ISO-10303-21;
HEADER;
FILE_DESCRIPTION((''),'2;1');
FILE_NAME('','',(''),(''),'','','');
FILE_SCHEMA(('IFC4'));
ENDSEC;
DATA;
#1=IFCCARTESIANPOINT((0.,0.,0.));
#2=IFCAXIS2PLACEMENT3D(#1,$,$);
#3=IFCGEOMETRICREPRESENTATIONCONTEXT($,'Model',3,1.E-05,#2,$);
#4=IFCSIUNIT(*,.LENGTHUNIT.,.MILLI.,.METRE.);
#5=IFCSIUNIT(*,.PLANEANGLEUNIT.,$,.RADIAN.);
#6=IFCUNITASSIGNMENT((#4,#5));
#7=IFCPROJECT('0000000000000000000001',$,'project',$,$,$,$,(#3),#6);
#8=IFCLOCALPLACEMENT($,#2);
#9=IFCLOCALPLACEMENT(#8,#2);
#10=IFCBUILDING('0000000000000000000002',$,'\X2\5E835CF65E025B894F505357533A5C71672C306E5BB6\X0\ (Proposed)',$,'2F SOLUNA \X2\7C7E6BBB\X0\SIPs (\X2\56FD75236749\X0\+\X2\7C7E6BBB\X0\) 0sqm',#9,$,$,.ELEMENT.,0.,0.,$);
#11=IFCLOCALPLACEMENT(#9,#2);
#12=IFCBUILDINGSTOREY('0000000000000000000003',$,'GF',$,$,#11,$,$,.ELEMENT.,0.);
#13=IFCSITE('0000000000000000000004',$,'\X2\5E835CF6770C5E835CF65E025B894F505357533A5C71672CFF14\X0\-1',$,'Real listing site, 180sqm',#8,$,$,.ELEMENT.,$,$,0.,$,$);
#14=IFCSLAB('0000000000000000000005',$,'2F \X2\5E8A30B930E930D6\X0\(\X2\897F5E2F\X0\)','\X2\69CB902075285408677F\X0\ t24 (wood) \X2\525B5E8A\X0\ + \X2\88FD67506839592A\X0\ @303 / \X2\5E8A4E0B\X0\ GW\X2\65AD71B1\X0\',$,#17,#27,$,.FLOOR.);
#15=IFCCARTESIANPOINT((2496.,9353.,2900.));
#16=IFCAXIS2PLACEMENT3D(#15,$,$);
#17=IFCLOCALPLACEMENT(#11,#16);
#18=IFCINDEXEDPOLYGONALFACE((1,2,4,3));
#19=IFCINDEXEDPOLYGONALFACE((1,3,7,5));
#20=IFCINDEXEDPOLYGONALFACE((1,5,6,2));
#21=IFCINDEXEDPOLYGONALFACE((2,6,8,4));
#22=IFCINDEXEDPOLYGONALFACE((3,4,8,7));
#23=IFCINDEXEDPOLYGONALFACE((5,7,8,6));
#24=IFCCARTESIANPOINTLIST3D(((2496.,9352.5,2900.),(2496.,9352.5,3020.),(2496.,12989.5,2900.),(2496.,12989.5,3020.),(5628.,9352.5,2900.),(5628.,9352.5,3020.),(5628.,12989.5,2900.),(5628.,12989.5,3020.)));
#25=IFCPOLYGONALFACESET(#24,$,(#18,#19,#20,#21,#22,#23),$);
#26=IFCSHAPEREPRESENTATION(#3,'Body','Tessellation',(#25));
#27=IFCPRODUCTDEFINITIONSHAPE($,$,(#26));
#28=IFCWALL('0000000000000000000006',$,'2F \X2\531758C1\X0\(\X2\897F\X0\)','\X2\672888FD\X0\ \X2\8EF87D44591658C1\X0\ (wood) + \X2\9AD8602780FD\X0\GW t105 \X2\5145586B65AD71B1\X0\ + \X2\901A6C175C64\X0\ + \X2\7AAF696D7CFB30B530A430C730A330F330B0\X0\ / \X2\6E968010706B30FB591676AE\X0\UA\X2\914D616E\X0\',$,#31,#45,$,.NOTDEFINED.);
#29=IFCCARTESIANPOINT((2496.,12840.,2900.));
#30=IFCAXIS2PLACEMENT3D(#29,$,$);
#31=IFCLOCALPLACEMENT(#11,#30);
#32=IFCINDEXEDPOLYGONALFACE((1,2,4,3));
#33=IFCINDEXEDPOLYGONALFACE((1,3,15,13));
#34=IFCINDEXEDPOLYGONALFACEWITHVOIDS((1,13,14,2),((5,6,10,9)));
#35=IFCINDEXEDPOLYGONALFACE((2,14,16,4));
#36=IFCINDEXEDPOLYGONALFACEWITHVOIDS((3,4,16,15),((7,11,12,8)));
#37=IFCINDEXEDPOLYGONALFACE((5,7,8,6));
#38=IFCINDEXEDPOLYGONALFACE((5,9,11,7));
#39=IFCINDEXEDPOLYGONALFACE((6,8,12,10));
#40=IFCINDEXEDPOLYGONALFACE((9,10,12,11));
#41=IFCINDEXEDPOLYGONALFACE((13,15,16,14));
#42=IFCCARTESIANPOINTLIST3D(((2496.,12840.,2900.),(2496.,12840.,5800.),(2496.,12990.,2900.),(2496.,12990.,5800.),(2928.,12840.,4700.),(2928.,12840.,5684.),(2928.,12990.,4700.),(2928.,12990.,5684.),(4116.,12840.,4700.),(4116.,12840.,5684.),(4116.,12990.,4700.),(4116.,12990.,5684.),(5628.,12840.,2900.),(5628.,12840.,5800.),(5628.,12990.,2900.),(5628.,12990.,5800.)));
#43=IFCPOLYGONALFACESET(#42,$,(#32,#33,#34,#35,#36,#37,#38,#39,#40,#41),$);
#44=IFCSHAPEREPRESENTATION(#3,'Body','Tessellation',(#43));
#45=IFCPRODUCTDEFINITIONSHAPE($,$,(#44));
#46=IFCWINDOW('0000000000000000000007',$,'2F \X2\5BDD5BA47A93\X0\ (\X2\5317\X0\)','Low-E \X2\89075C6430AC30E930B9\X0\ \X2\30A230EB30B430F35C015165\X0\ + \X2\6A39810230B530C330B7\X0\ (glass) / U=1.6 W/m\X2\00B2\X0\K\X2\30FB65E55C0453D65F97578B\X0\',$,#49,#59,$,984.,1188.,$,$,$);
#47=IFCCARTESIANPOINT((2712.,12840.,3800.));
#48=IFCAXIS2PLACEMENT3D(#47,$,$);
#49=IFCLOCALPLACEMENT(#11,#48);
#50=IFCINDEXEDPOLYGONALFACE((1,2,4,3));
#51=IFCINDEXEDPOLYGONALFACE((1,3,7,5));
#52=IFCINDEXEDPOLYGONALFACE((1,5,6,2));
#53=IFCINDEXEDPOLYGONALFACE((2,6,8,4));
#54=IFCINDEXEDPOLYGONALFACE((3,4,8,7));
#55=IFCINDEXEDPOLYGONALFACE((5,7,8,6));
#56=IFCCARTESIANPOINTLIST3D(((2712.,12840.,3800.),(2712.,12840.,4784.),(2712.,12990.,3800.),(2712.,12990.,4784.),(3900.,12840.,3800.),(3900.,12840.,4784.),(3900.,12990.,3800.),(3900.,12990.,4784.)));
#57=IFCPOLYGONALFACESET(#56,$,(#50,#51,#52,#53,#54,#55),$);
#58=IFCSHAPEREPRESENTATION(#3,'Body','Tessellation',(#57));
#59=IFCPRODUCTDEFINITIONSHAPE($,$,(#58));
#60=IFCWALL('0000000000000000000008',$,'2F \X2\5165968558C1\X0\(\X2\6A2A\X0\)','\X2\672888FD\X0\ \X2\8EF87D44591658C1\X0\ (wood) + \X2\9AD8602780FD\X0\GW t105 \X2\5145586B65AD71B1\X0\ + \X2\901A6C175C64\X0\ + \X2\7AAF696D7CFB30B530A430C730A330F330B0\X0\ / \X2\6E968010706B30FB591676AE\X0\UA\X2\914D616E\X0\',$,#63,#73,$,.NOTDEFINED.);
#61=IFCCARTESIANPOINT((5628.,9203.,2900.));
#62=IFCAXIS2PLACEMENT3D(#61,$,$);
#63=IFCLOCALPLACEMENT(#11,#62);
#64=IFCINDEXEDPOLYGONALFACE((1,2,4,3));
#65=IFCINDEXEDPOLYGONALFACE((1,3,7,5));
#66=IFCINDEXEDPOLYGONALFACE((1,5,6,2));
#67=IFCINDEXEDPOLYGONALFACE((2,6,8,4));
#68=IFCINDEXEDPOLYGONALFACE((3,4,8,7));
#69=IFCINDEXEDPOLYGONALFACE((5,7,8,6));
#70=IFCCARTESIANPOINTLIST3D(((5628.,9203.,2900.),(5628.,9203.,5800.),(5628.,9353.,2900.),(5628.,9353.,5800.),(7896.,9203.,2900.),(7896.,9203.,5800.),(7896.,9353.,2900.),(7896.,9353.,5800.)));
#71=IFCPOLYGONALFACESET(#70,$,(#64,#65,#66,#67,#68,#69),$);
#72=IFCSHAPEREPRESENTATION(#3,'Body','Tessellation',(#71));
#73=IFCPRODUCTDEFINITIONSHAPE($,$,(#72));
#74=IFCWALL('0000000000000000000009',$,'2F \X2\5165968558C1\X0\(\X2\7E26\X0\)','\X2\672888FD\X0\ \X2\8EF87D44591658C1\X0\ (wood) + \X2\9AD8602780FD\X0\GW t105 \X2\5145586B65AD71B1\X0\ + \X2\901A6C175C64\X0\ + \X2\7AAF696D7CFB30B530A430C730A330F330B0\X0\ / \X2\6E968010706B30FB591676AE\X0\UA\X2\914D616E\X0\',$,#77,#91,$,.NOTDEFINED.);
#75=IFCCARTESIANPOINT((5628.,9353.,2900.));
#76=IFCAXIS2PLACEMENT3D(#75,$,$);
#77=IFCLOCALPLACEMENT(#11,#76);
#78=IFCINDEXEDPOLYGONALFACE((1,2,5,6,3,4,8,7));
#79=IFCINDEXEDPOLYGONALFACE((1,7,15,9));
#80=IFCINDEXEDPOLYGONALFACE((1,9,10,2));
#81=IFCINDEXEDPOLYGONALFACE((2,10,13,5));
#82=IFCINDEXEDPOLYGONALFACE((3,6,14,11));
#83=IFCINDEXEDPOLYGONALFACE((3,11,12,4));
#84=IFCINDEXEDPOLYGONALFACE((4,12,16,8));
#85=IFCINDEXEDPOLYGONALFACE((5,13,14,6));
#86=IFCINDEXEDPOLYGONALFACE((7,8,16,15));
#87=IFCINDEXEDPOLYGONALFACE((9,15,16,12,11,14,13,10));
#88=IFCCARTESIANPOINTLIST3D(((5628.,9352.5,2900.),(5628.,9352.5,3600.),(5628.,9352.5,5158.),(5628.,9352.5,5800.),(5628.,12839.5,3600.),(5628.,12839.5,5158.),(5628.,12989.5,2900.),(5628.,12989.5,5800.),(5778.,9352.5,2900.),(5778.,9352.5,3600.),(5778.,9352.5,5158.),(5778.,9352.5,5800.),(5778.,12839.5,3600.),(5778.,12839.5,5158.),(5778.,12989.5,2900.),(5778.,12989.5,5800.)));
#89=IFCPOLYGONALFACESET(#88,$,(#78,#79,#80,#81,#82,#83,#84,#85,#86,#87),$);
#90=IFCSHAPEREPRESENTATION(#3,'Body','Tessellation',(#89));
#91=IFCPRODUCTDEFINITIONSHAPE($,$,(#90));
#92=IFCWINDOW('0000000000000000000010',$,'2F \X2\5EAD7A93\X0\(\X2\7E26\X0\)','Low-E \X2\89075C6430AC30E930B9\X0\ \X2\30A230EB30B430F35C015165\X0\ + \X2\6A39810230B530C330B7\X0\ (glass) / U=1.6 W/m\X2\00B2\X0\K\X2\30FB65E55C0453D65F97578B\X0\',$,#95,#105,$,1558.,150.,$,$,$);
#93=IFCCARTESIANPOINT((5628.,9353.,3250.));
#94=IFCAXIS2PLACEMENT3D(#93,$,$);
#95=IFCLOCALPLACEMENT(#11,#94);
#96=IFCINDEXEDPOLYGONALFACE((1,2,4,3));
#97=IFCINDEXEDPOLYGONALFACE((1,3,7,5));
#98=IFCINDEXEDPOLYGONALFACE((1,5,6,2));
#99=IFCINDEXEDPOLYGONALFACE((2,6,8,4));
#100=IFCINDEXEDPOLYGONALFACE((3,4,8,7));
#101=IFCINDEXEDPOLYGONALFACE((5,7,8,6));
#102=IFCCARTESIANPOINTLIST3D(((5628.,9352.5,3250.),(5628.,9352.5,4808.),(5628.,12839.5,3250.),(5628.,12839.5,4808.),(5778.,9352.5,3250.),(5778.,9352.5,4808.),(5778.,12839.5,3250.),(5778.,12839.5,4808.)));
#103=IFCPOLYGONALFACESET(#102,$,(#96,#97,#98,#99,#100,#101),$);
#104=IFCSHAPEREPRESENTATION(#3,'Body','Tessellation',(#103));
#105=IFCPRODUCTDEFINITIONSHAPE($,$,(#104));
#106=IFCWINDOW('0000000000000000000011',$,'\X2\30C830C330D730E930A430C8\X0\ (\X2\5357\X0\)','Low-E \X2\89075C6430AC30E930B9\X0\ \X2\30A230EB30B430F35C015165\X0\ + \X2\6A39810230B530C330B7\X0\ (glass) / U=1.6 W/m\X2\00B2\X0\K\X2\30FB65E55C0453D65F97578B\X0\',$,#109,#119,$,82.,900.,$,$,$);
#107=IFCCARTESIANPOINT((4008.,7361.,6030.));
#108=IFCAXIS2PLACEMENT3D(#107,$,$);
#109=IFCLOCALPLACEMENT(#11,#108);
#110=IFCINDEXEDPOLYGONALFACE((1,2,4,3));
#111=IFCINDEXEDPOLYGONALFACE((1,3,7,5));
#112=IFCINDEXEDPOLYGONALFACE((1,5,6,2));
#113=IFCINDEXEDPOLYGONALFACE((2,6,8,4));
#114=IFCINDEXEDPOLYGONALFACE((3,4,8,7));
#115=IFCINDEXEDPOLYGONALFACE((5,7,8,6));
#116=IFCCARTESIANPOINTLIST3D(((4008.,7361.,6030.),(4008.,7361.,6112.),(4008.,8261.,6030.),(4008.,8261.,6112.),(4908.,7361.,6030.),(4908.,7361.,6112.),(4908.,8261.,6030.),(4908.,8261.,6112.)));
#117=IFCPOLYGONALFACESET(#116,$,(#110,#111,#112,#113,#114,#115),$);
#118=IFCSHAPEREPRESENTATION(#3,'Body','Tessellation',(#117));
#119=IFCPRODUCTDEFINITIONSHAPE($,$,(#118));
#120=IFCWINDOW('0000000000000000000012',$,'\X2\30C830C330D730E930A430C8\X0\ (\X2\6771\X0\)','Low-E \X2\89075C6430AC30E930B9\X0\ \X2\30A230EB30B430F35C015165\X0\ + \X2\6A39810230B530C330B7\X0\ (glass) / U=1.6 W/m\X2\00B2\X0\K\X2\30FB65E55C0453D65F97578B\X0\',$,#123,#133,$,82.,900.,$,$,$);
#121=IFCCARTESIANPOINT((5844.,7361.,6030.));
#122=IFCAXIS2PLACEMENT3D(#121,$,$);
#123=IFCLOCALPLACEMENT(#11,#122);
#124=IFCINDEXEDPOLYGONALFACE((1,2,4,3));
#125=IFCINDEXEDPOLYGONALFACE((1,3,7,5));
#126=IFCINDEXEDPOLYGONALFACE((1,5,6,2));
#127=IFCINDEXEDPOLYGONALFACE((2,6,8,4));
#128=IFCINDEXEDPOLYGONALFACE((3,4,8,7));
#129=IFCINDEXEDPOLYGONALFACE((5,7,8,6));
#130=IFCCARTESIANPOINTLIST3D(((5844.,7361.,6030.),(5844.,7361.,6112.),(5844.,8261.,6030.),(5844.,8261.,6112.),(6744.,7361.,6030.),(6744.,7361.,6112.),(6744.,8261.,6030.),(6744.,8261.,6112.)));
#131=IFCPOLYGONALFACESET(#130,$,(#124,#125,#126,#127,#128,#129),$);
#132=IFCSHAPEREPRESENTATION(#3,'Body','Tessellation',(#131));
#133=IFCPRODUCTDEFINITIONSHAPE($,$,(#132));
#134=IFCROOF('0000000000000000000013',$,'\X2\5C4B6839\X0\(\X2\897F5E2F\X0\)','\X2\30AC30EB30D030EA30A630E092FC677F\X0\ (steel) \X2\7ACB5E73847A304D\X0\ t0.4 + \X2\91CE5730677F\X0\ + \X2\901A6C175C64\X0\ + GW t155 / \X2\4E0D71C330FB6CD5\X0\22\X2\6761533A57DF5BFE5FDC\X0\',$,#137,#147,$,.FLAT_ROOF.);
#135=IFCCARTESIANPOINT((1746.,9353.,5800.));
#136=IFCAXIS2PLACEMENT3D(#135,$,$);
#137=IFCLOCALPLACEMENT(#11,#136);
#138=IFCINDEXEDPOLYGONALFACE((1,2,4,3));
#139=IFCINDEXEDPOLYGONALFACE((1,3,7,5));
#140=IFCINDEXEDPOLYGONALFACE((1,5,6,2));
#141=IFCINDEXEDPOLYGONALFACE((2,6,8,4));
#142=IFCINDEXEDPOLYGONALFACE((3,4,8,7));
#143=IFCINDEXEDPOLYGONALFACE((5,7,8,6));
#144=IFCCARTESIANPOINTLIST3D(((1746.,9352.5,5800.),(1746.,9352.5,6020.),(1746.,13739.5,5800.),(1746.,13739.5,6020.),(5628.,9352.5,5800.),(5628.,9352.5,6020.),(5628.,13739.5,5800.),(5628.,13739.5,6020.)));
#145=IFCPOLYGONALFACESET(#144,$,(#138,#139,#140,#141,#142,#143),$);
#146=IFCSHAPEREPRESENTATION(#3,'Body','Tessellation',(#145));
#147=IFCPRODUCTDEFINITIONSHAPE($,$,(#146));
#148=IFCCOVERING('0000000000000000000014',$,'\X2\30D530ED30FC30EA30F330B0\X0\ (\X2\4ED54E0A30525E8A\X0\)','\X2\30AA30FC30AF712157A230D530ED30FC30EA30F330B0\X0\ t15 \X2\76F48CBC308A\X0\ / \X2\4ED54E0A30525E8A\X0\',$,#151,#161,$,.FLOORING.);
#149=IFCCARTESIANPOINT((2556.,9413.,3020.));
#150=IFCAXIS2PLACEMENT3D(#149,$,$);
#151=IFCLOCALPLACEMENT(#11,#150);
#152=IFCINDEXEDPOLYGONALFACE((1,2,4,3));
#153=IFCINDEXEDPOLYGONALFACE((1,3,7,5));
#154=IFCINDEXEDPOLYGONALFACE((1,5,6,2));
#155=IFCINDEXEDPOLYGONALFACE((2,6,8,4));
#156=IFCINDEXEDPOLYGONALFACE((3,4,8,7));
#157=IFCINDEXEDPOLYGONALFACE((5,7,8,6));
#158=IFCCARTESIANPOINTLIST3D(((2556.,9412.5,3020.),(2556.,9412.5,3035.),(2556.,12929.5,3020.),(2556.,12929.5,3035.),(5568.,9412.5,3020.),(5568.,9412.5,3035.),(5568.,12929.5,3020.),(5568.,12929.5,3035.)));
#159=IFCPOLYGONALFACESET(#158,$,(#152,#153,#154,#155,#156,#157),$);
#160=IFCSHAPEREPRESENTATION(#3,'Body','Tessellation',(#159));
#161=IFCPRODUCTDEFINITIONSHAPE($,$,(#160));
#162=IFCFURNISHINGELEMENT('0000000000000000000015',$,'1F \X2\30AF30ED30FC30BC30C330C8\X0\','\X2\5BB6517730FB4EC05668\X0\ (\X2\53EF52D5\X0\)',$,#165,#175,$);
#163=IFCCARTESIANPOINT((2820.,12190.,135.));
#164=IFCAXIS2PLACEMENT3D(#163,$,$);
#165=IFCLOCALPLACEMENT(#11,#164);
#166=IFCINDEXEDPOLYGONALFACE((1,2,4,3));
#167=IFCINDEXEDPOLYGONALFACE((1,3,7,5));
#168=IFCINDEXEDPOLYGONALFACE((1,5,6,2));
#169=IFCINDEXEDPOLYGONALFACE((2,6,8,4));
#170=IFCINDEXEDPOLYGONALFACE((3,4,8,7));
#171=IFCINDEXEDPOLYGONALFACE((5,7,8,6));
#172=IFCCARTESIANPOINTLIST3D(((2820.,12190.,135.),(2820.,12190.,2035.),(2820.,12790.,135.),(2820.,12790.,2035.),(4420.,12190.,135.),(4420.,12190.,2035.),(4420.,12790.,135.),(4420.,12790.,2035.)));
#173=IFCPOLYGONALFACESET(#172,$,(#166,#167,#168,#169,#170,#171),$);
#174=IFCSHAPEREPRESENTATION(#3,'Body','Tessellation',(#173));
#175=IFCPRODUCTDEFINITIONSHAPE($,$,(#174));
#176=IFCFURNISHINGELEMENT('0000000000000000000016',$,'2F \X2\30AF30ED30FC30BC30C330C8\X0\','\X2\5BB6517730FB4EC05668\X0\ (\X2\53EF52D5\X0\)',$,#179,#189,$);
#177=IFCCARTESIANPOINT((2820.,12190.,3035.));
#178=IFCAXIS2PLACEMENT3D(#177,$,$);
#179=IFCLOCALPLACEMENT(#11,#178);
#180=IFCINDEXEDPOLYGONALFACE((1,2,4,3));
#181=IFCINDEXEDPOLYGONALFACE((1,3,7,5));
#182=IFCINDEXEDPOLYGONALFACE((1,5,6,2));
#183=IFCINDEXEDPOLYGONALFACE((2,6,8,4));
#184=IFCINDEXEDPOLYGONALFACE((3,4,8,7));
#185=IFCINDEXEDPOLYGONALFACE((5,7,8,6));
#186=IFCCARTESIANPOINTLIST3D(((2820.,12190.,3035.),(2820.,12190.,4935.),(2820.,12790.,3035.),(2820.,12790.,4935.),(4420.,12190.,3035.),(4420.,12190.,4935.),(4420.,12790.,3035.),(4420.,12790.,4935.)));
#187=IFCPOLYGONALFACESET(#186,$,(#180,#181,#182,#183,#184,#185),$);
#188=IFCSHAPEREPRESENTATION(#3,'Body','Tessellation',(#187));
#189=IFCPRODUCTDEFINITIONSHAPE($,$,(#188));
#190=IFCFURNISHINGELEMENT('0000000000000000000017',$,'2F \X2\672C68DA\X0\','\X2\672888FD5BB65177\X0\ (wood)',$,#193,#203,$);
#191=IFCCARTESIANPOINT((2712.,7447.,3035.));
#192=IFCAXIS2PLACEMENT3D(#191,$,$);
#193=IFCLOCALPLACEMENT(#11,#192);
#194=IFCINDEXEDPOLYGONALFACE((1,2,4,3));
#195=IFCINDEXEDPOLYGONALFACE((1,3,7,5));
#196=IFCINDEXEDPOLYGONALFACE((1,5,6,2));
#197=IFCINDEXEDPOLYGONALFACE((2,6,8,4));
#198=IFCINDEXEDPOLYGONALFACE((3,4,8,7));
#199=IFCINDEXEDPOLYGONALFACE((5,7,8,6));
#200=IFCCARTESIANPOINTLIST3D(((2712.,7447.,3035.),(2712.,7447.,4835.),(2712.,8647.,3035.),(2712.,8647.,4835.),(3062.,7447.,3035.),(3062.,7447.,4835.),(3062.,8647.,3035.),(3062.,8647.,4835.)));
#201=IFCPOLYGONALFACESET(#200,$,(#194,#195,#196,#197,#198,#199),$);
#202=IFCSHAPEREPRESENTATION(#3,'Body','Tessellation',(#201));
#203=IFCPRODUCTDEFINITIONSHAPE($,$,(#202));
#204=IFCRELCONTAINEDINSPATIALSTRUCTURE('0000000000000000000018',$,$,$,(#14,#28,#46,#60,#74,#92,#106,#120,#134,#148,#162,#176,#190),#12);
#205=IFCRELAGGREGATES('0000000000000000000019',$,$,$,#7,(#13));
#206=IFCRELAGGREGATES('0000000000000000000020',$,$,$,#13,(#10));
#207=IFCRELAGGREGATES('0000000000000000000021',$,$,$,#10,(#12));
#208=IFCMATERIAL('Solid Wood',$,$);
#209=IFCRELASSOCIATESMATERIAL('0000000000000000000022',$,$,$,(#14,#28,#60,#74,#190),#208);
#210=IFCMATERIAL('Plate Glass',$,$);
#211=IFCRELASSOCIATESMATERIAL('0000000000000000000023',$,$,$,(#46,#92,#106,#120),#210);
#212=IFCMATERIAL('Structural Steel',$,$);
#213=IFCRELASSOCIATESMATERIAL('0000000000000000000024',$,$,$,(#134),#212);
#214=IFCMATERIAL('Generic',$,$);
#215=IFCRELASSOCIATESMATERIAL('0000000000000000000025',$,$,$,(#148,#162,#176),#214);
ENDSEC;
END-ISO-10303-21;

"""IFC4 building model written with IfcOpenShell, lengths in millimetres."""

from ifc_helpers import new_model, si_unit, frame, frame_2d, origin, place, context, project, spatial, rectangle, extrude, material, element, fill, save


model = new_model("IFC4")

# Units and contexts
model_context = context("Model", 3, precision=1e-05, world=origin())
ifc_project = project(units=[si_unit("LENGTHUNIT", "METRE", prefix="MILLI"), si_unit("PLANEANGLEUNIT", "RADIAN")], contexts=[model_context])

# Site, building, storey
site_placement = place(None, origin())
site = spatial("IfcSite", under=ifc_project, at=site_placement, Name="広島県広島市安佐南区山本４-1", ObjectType="Real listing site, 180sqm", CompositionType="ELEMENT", RefElevation=0.0)
building_placement = place(site_placement, origin())
building = spatial("IfcBuilding", under=site, at=building_placement, Name="広島市安佐南区山本の家 (Proposed)", ObjectType="2F SOLUNA 籾殻SIPs (国産杉+籾殻) 0sqm", CompositionType="ELEMENT", ElevationOfRefHeight=0.0, ElevationOfTerrain=0.0)
storey_placement = place(building_placement, origin())
storey = spatial("IfcBuildingStorey", under=building, at=storey_placement, Name="GF", CompositionType="ELEMENT", Elevation=0.0)

# Slab
ifc_material_1 = material(Name="Solid Wood")
slab_placement = place(storey_placement, frame((2496.0, 9353.0, 2900.0)))
element("IfcSlab", 1, at=slab_placement, inside=storey, material=ifc_material_1, Name="2F 床スラブ(西帯)", Description="構造用合板 t24 (wood) 剛床 + 製材根太 @303 / 床下 GW断熱", PredefinedType="FLOOR", context=model_context, shape_type="SweptSolid", body=[
    extrude(rectangle(XDim=3132.0, YDim=3637.0, at=frame_2d((1566.0, 1818.0))), frame((2496.0, 9353.0, 2900.0)), (0.0, 0.0, 1.0), 120.0),
])

# Wall, opening, window
wall_1_placement = place(storey_placement, frame((2496.0, 12840.0, 2900.0)))
wall_1 = element("IfcWall", 2, at=wall_1_placement, inside=storey, material=ifc_material_1, Name="2F 北壁(西)", Description="木製 軸組外壁 (wood) + 高性能GW t105 充填断熱 + 通気層 + 窯業系サイディング / 準耐火・外皮UA配慮", PredefinedType="NOTDEFINED", context=model_context, shape_type="SweptSolid", body=[
    extrude(rectangle(XDim=3132.0, YDim=150.0, at=frame_2d((1566.0, 75.0))), frame((2496.0, 12840.0, 2900.0)), (0.0, 0.0, 1.0), 2900.0),
])
opening_1_placement = place(storey_placement, frame((2712.0, 12840.0, 3800.0)))
opening_1 = element("IfcOpeningElement", 3, at=opening_1_placement, cuts=wall_1, PredefinedType="NOTDEFINED", context=model_context, shape_type="SweptSolid", body=[
    extrude(rectangle(XDim=1188.0, YDim=150.0, at=frame_2d((594.0, 75.0))), frame((2712.0, 12840.0, 3800.0)), (0.0, 0.0, 1.0), 984.0),
])
ifc_material_2 = material(Name="Plate Glass")
window_1_placement = place(storey_placement, frame((2712.0, 12840.0, 3800.0)))
window_1 = element("IfcWindow", 4, at=window_1_placement, inside=storey, material=ifc_material_2, Name="2F 寝室窓 (北)", Description="Low-E 複層ガラス アルゴン封入 + 樹脂サッシ (glass) / U=1.6 W/m²K・日射取得型", OverallHeight=984.0, OverallWidth=1188.0, context=model_context, shape_type="SweptSolid", body=[
    extrude(rectangle(XDim=1188.0, YDim=150.0, at=frame_2d((594.0, 75.0))), frame((2712.0, 12840.0, 3800.0)), (0.0, 0.0, 1.0), 984.0),
])
fill(opening_1, window_1)

# Wall
wall_2_placement = place(storey_placement, frame((5628.0, 9203.0, 2900.0)))
element("IfcWall", 5, at=wall_2_placement, inside=storey, material=ifc_material_1, Name="2F 入隅壁(横)", Description="木製 軸組外壁 (wood) + 高性能GW t105 充填断熱 + 通気層 + 窯業系サイディング / 準耐火・外皮UA配慮", PredefinedType="NOTDEFINED", context=model_context, shape_type="SweptSolid", body=[
    extrude(rectangle(XDim=2268.0, YDim=150.0, at=frame_2d((1134.0, 75.0))), frame((5628.0, 9203.0, 2900.0)), (0.0, 0.0, 1.0), 2900.0),
])

# Wall, opening, window
wall_3_placement = place(storey_placement, frame((5628.0, 9353.0, 2900.0)))
wall_3 = element("IfcWall", 6, at=wall_3_placement, inside=storey, material=ifc_material_1, Name="2F 入隅壁(縦)", Description="木製 軸組外壁 (wood) + 高性能GW t105 充填断熱 + 通気層 + 窯業系サイディング / 準耐火・外皮UA配慮", PredefinedType="NOTDEFINED", context=model_context, shape_type="SweptSolid", body=[
    extrude(rectangle(XDim=150.0, YDim=3637.0, at=frame_2d((75.0, 1818.0))), frame((5628.0, 9353.0, 2900.0)), (0.0, 0.0, 1.0), 2900.0),
])
opening_2_placement = place(storey_placement, frame((5628.0, 9353.0, 3250.0)))
opening_2 = element("IfcOpeningElement", 7, at=opening_2_placement, cuts=wall_3, PredefinedType="NOTDEFINED", context=model_context, shape_type="SweptSolid", body=[
    extrude(rectangle(XDim=150.0, YDim=3487.0, at=frame_2d((75.0, 1743.0))), frame((5628.0, 9353.0, 3250.0)), (0.0, 0.0, 1.0), 1558.0),
])
window_2_placement = place(storey_placement, frame((5628.0, 9353.0, 3250.0)))
window_2 = element("IfcWindow", 8, at=window_2_placement, inside=storey, material=ifc_material_2, Name="2F 庭窓(縦)", Description="Low-E 複層ガラス アルゴン封入 + 樹脂サッシ (glass) / U=1.6 W/m²K・日射取得型", OverallHeight=1558.0, OverallWidth=150.0, context=model_context, shape_type="SweptSolid", body=[
    extrude(rectangle(XDim=150.0, YDim=3487.0, at=frame_2d((75.0, 1743.0))), frame((5628.0, 9353.0, 3250.0)), (0.0, 0.0, 1.0), 1558.0),
])
fill(opening_2, window_2)

# Windows
window_3_placement = place(storey_placement, frame((4008.0, 7361.0, 6030.0)))
element("IfcWindow", 9, at=window_3_placement, inside=storey, material=ifc_material_2, Name="トップライト (南)", Description="Low-E 複層ガラス アルゴン封入 + 樹脂サッシ (glass) / U=1.6 W/m²K・日射取得型", OverallHeight=82.0, OverallWidth=900.0, context=model_context, shape_type="SweptSolid", body=[
    extrude(rectangle(XDim=900.0, YDim=900.0, at=frame_2d((450.0, 450.0))), frame((4008.0, 7361.0, 6030.0)), (0.0, 0.0, 1.0), 82.0),
])
window_4_placement = place(storey_placement, frame((5844.0, 7361.0, 6030.0)))
element("IfcWindow", 10, at=window_4_placement, inside=storey, material=ifc_material_2, Name="トップライト (東)", Description="Low-E 複層ガラス アルゴン封入 + 樹脂サッシ (glass) / U=1.6 W/m²K・日射取得型", OverallHeight=82.0, OverallWidth=900.0, context=model_context, shape_type="SweptSolid", body=[
    extrude(rectangle(XDim=900.0, YDim=900.0, at=frame_2d((450.0, 450.0))), frame((5844.0, 7361.0, 6030.0)), (0.0, 0.0, 1.0), 82.0),
])

# Roof
ifc_material_3 = material(Name="Structural Steel")
for number, where, name in (
    (11, (1746.0, 9353.0, 5800.0), "屋根(西帯)"),
):
    element("IfcRoof", number, at=place(storey_placement, frame(where)), inside=storey, material=ifc_material_3, Name=name, Description="ガルバリウム鋼板 (steel) 立平葺き t0.4 + 野地板 + 通気層 + GW t155 / 不燃・法22条区域対応", PredefinedType="FLAT_ROOF", context=model_context, shape_type="SweptSolid", body=[
        extrude(rectangle(XDim=3882.0, YDim=4387.0, at=frame_2d((1941.0, 2193.0))), frame((1746.0, 9353.0, 5800.0)), (0.0, 0.0, 1.0), 220.0),
    ])

# Covering
ifc_material_4 = material(Name="Generic")
covering_placement = place(storey_placement, frame((2556.0, 9413.0, 3020.0)))
element("IfcCovering", 12, at=covering_placement, inside=storey, material=ifc_material_4, Name="フローリング (仕上げ床)", Description="オーク無垢フローリング t15 直貼り / 仕上げ床", PredefinedType="FLOORING", context=model_context, shape_type="SweptSolid", body=[
    extrude(rectangle(XDim=3012.0, YDim=3517.0, at=frame_2d((1506.0, 1758.0))), frame((2556.0, 9413.0, 3020.0)), (0.0, 0.0, 1.0), 15.0),
])

# Furnishing elements
furnishing_1_placement = place(storey_placement, frame((2820.0, 12190.0, 135.0)))
element("IfcFurnishingElement", 13, at=furnishing_1_placement, inside=storey, material=ifc_material_4, Name="1F クローゼット", Description="家具・什器 (可動)", context=model_context, shape_type="SweptSolid", body=[
    extrude(rectangle(XDim=1600.0, YDim=600.0, at=frame_2d((800.0, 300.0))), frame((2820.0, 12190.0, 135.0)), (0.0, 0.0, 1.0), 1900.0),
])
furnishing_2_placement = place(storey_placement, frame((2820.0, 12190.0, 3035.0)))
element("IfcFurnishingElement", 14, at=furnishing_2_placement, inside=storey, material=ifc_material_4, Name="2F クローゼット", Description="家具・什器 (可動)", context=model_context, shape_type="SweptSolid", body=[
    extrude(rectangle(XDim=1600.0, YDim=600.0, at=frame_2d((800.0, 300.0))), frame((2820.0, 12190.0, 3035.0)), (0.0, 0.0, 1.0), 1900.0),
])
furnishing_3_placement = place(storey_placement, frame((2712.0, 7447.0, 3035.0)))
element("IfcFurnishingElement", 15, at=furnishing_3_placement, inside=storey, material=ifc_material_1, Name="2F 本棚", Description="木製家具 (wood)", context=model_context, shape_type="SweptSolid", body=[
    extrude(rectangle(XDim=350.0, YDim=1200.0, at=frame_2d((175.0, 600.0))), frame((2712.0, 7447.0, 3035.0)), (0.0, 0.0, 1.0), 1800.0),
])

save(model, "model.ifc")
